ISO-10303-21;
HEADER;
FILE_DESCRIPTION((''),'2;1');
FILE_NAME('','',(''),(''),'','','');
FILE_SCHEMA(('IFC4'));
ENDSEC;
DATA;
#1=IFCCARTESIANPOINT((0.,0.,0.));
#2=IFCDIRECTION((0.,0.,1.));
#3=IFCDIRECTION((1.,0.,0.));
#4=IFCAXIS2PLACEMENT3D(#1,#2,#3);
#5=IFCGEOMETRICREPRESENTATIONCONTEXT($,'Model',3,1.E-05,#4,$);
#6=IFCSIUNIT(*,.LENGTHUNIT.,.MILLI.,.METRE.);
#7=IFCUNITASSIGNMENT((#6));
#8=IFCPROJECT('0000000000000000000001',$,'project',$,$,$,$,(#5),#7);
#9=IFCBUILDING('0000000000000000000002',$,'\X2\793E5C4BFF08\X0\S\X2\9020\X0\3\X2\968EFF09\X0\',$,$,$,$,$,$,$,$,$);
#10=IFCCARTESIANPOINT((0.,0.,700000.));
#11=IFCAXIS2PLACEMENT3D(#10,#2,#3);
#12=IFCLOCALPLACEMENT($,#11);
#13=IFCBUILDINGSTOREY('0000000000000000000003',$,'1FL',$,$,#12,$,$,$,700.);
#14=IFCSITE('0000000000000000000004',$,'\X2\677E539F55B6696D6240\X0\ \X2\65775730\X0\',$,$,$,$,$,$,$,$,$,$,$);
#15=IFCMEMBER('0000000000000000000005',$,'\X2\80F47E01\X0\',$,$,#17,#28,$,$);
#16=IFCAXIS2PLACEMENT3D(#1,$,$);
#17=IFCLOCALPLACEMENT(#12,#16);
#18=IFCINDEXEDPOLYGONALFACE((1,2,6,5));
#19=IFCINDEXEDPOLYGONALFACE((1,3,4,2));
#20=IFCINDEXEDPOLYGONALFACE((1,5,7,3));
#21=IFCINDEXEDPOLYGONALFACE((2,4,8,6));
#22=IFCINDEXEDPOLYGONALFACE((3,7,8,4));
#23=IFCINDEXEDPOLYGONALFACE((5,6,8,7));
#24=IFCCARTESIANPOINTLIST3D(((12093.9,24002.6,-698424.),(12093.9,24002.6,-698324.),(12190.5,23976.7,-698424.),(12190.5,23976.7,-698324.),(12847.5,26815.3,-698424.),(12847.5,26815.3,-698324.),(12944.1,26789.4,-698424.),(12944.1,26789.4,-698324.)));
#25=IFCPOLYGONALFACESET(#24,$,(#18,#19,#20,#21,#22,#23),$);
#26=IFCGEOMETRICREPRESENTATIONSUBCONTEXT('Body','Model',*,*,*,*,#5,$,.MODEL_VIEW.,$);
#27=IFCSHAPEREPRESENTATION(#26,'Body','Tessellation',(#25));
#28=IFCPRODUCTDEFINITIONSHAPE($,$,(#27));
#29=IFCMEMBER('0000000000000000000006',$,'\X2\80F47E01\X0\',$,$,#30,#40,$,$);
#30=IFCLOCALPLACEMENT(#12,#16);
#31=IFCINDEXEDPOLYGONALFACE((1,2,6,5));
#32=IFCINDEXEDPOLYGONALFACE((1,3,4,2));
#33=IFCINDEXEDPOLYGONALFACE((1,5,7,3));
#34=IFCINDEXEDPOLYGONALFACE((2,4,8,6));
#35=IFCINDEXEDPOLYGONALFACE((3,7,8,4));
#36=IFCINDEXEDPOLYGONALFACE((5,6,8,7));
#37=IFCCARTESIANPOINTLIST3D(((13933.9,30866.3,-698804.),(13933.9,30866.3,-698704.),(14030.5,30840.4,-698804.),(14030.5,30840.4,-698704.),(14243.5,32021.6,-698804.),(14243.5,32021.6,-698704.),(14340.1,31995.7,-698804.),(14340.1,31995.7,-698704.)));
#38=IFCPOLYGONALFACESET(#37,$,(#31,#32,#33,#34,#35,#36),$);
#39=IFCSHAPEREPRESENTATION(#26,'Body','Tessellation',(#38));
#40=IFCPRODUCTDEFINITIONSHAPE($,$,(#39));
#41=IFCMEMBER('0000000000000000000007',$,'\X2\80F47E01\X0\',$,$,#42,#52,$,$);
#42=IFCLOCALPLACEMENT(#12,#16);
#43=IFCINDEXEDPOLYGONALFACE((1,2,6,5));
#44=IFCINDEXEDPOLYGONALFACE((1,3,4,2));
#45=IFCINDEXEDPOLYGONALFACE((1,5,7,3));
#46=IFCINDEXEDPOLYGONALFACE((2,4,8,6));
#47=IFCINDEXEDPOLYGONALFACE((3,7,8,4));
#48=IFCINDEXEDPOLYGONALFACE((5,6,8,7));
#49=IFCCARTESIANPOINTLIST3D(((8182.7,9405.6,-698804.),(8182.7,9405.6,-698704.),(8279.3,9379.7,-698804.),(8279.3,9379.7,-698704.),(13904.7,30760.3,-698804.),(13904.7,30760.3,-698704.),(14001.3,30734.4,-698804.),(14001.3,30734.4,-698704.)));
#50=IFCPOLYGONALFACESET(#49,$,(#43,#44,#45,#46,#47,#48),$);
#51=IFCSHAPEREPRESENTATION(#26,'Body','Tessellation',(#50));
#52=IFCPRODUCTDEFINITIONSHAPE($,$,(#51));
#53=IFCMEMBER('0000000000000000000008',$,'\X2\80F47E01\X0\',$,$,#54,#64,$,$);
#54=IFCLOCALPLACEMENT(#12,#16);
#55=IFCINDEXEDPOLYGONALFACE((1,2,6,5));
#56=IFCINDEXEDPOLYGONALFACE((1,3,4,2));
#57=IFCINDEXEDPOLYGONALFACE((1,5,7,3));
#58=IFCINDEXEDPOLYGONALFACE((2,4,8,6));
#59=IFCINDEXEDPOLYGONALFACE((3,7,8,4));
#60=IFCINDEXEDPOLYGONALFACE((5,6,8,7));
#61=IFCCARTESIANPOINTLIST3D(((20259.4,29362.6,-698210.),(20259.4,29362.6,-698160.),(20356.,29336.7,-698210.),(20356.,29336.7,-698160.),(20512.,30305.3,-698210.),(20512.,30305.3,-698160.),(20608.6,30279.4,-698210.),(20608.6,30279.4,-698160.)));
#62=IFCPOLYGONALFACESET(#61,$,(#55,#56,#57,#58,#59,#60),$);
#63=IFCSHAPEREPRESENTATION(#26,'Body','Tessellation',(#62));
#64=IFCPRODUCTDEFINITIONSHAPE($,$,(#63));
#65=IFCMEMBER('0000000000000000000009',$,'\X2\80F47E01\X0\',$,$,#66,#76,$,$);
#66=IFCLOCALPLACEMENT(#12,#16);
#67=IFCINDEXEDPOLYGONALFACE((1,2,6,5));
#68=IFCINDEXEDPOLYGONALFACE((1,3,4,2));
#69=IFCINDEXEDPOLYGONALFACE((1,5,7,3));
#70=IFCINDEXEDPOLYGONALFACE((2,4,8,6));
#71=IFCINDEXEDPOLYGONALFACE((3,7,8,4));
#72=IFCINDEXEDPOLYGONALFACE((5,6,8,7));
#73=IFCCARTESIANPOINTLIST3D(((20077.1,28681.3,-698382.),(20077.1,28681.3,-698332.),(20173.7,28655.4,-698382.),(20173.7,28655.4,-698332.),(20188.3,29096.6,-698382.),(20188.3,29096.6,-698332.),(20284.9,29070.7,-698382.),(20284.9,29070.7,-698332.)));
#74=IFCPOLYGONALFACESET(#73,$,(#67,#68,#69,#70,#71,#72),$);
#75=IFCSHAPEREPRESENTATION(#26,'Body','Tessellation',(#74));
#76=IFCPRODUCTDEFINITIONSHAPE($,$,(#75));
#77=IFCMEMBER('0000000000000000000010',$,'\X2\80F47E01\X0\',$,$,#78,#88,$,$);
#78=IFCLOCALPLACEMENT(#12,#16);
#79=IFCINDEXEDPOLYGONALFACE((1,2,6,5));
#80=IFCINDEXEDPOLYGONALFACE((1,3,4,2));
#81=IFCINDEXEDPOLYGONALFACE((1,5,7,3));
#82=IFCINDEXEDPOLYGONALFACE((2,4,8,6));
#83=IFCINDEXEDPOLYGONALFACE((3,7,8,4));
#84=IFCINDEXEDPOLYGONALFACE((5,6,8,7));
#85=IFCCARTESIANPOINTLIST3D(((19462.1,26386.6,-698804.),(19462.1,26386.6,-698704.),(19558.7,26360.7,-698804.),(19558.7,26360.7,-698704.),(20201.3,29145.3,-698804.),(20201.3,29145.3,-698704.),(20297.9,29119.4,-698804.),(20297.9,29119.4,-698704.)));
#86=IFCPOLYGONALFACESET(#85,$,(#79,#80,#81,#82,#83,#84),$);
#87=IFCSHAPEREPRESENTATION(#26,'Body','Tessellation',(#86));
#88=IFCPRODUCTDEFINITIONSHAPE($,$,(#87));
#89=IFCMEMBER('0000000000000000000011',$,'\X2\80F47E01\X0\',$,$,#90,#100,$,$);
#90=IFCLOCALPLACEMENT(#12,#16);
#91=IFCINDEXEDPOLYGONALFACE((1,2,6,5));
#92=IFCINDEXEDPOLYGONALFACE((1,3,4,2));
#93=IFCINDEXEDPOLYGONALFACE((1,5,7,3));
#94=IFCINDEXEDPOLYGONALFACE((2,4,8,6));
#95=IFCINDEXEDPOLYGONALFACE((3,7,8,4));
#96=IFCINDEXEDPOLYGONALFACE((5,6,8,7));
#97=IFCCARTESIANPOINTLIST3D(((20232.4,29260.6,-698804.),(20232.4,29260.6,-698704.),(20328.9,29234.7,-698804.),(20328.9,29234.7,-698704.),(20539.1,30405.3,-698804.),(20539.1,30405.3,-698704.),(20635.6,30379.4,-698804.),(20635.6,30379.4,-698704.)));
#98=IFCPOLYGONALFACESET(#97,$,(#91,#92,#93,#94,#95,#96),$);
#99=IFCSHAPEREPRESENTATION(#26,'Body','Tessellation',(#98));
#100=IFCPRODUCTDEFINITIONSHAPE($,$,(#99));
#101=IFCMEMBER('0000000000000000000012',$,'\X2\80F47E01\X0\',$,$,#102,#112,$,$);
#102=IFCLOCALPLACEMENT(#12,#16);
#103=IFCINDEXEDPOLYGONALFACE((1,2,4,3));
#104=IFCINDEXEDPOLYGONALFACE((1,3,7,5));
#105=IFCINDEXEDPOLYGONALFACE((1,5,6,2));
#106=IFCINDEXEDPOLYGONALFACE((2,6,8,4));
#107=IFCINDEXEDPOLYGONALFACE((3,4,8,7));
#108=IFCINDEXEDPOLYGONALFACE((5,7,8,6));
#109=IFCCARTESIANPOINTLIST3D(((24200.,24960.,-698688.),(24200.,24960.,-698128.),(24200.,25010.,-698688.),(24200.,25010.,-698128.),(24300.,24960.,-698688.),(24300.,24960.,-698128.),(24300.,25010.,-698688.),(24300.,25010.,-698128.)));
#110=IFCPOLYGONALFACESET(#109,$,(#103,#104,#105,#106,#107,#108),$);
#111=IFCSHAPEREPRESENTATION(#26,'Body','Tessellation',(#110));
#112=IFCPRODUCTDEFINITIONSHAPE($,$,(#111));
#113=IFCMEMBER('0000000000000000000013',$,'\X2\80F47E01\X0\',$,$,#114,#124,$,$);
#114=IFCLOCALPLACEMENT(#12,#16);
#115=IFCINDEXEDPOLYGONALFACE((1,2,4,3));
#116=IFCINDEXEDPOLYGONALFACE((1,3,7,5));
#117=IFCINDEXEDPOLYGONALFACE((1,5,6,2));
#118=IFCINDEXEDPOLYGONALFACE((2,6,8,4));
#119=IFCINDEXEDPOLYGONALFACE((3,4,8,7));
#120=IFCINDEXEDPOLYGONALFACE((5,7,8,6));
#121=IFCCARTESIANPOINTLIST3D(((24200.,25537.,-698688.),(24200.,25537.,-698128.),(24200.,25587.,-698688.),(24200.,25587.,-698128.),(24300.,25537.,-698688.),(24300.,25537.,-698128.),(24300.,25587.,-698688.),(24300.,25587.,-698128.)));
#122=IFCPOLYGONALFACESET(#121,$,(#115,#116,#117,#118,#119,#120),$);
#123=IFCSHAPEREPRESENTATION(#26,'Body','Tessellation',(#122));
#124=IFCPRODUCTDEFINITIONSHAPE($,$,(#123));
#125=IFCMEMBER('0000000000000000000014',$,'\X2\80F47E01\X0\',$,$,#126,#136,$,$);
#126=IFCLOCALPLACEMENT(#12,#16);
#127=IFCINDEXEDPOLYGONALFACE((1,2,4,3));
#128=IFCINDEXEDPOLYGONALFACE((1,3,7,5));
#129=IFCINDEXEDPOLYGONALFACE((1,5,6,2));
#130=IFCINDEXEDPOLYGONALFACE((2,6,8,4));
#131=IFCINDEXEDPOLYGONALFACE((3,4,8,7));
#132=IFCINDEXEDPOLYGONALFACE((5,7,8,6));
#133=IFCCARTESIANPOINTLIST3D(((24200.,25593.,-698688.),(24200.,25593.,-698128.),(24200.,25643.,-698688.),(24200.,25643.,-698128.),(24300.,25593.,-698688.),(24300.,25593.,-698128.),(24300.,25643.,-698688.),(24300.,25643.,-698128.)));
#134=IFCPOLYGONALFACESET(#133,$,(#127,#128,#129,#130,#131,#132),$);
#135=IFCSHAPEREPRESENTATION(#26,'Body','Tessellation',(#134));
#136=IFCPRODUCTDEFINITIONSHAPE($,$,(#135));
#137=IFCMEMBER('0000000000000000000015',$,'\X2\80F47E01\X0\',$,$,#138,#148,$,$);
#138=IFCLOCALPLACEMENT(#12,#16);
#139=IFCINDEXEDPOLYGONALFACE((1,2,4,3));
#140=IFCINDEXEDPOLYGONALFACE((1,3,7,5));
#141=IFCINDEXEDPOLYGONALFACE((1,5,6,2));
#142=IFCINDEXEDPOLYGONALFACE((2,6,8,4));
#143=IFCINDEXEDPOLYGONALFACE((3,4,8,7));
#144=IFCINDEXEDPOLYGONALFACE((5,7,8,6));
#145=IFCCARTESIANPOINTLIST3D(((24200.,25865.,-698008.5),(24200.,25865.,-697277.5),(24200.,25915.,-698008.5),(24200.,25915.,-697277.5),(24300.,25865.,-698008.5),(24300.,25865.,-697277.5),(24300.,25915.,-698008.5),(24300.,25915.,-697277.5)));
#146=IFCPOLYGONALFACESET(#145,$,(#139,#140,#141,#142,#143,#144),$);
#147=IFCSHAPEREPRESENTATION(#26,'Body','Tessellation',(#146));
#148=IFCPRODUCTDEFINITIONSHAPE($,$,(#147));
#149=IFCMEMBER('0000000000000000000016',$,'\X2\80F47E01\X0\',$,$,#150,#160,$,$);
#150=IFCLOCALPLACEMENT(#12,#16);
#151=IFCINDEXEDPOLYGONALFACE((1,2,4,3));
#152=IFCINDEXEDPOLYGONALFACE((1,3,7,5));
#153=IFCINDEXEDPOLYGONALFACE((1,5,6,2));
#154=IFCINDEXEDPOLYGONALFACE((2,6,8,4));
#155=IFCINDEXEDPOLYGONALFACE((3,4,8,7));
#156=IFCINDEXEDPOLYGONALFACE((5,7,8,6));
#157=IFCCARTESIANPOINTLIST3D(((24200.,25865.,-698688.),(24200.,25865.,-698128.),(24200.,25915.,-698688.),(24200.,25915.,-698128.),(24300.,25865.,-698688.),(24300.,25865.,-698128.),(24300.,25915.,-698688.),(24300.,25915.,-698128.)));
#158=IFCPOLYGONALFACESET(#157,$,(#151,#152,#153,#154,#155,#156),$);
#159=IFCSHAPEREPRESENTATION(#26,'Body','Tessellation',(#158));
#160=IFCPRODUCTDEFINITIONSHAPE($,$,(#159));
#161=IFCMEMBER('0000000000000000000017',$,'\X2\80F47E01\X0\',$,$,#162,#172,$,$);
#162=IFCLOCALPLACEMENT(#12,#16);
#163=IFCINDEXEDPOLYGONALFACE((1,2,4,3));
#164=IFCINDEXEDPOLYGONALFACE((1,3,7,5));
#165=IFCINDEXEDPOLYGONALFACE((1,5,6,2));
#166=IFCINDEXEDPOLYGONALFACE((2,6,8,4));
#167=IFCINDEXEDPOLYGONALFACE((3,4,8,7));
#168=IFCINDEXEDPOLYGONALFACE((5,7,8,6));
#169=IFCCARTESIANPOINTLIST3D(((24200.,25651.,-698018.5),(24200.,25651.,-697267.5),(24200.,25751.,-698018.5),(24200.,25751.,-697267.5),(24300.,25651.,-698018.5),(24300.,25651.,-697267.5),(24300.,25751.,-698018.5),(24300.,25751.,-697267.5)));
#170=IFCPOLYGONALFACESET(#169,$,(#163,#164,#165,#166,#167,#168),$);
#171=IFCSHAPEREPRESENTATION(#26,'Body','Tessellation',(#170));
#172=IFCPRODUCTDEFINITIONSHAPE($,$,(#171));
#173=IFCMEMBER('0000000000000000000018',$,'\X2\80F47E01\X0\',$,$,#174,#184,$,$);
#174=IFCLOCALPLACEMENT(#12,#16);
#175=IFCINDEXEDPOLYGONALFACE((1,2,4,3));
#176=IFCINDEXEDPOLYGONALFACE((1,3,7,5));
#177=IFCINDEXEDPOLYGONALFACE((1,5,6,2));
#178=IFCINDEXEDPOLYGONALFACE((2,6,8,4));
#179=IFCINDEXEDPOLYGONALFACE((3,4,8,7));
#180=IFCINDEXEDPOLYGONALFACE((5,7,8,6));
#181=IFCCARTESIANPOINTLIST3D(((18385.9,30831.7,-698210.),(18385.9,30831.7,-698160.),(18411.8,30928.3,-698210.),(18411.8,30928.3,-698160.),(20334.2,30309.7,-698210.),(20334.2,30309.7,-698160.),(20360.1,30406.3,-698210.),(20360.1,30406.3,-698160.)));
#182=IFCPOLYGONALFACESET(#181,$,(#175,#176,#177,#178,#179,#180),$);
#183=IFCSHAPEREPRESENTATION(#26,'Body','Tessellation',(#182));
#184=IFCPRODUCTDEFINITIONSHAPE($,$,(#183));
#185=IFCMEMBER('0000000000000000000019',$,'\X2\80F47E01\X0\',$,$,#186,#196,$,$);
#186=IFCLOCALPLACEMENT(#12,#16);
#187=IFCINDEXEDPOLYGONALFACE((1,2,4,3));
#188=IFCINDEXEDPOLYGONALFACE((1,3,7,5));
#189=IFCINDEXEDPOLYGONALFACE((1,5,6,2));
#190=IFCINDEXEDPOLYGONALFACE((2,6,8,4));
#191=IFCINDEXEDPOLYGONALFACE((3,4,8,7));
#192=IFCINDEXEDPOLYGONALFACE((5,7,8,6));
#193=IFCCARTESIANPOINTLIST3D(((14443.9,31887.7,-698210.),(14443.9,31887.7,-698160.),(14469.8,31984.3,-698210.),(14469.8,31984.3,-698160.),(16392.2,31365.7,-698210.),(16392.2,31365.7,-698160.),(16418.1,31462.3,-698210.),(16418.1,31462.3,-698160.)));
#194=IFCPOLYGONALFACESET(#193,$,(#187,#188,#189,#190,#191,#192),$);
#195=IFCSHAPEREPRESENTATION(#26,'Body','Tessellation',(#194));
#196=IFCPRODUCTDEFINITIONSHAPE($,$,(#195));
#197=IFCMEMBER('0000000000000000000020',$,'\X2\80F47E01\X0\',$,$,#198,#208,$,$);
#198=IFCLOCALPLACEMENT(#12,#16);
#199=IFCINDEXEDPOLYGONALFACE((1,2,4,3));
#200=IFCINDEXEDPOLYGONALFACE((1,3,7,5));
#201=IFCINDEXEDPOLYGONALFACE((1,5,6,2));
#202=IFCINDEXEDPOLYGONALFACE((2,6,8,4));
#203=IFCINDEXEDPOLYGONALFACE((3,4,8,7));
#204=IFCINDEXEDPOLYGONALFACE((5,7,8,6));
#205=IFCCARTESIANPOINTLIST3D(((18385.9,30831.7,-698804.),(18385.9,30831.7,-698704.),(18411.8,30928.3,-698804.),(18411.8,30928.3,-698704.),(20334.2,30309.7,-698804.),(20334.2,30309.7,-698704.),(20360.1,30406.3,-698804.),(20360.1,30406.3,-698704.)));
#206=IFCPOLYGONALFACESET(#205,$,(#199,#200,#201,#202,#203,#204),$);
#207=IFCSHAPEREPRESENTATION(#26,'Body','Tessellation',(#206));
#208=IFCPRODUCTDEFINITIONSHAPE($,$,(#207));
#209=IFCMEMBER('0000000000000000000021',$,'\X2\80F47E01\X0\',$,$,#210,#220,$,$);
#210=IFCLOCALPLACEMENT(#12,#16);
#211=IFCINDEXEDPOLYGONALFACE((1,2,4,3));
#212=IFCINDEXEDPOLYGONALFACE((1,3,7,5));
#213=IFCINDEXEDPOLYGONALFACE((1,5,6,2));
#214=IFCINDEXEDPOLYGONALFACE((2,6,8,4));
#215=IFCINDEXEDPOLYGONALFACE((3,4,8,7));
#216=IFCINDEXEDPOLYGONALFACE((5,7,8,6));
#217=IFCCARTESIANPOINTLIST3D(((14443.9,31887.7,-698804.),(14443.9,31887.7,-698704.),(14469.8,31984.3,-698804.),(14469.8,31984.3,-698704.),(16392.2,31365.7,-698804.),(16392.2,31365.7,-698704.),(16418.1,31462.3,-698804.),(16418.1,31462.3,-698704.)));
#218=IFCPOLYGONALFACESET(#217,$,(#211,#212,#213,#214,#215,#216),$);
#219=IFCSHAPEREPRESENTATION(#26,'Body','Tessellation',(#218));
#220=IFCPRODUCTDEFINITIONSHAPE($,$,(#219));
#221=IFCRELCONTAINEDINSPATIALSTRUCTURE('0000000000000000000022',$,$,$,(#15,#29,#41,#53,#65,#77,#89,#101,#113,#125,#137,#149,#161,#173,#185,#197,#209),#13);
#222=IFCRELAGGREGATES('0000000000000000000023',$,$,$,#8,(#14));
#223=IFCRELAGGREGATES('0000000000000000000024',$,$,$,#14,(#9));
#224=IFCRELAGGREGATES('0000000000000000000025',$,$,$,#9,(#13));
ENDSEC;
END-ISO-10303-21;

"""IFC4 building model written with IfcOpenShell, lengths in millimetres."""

from ifc_helpers import new_model, si_unit, frame, origin, origin_with_axes, place, context, subcontext, project, spatial, rectangle, extrude, element, save


model = new_model("IFC4")

# Units and contexts
model_context = context("Model", 3, precision=1e-05, world=origin_with_axes())
body_context = subcontext(model_context, "Body", "Model", "MODEL_VIEW")
ifc_project = project(units=[si_unit("LENGTHUNIT", "METRE", prefix="MILLI")], contexts=[model_context])

# Site, building, storey
site = spatial("IfcSite", under=ifc_project, Name="松原営業所 敷地")
building = spatial("IfcBuilding", under=site, Name="社屋（S造3階）")
storey_placement = place(None, frame((0.0, 0.0, 700000.0), z_axis=(0.0, 0.0, 1.0), x_axis=(1.0, 0.0, 0.0)))
storey = spatial("IfcBuildingStorey", under=building, at=storey_placement, Name="1FL", Elevation=700.0)

# Members
member_1_placement = place(storey_placement, frame((12895.8, 26802.4, -698374.0), z_axis=(-0.258819, -0.965926, 0.0), x_axis=(0.965926, -0.258819, 0.0)))
element("IfcMember", 1, at=member_1_placement, inside=storey, Name="胴縁", context=body_context, shape_type="SweptSolid", body=[
    extrude(rectangle(XDim=100.0, YDim=100.0), origin(), (0.0, 0.0, 1.0), 2912.0),
])
member_2_placement = place(storey_placement, frame((14291.8, 32008.6, -698754.0), z_axis=(-0.258819, -0.965926, 0.0), x_axis=(0.965926, -0.258819, 0.0)))
element("IfcMember", 2, at=member_2_placement, inside=storey, Name="胴縁", context=body_context, shape_type="SweptSolid", body=[
    extrude(rectangle(XDim=100.0, YDim=100.0), origin(), (0.0, 0.0, 1.0), 1196.0),
])
member_3_placement = place(storey_placement, frame((13953.0, 30747.3, -698754.0), z_axis=(-0.258819, -0.965926, 0.0), x_axis=(0.965926, -0.258819, 0.0)))
element("IfcMember", 3, at=member_3_placement, inside=storey, Name="胴縁", context=body_context, shape_type="SweptSolid", body=[
    extrude(rectangle(XDim=100.0, YDim=100.0), origin(), (0.0, 0.0, 1.0), 22108.0),
])
member_4_placement = place(storey_placement, frame((20307.7, 29349.6, -698185.0), z_axis=(0.258819, 0.965926, 0.0), x_axis=(-0.965926, 0.258819, 0.0)))
element("IfcMember", 4, at=member_4_placement, inside=storey, Name="胴縁", context=body_context, shape_type="SweptSolid", body=[
    extrude(rectangle(XDim=100.0, YDim=50.0), origin(), (0.0, 0.0, 1.0), 976.0),
])
member_5_placement = place(storey_placement, frame((20125.4, 28668.3, -698357.0), z_axis=(0.258819, 0.965926, 0.0), x_axis=(-0.965926, 0.258819, 0.0)))
element("IfcMember", 5, at=member_5_placement, inside=storey, Name="胴縁", context=body_context, shape_type="SweptSolid", body=[
    extrude(rectangle(XDim=100.0, YDim=50.0), origin(), (0.0, 0.0, 1.0), 430.0),
])
member_6_placement = place(storey_placement, frame((19510.4, 26373.7, -698754.0), z_axis=(0.258819, 0.965926, 0.0), x_axis=(-0.965926, 0.258819, 0.0)))
element("IfcMember", 6, at=member_6_placement, inside=storey, Name="胴縁", context=body_context, shape_type="SweptSolid", body=[
    extrude(rectangle(XDim=100.0, YDim=100.0), origin(), (0.0, 0.0, 1.0), 2856.0),
])
member_7_placement = place(storey_placement, frame((20280.6, 29247.7, -698754.0), z_axis=(0.258819, 0.965926, 0.0), x_axis=(-0.965926, 0.258819, 0.0)))
element("IfcMember", 7, at=member_7_placement, inside=storey, Name="胴縁", context=body_context, shape_type="SweptSolid", body=[
    extrude(rectangle(XDim=100.0, YDim=100.0), origin(), (0.0, 0.0, 1.0), 1185.0),
])
for number, where, z_axis, x_axis, name in (
    (8, (24250.0, 24960.0, -698408.0), (0.0, 1.0, 0.0), (-1.0, 0.0, 0.0), "胴縁"),
    (9, (24250.0, 25537.0, -698408.0), (0.0, 1.0, 0.0), (-1.0, 0.0, 0.0), "胴縁"),
    (10, (24250.0, 25593.0, -698408.0), (0.0, 1.0, 0.0), (-1.0, 0.0, 0.0), "胴縁"),
):
    element("IfcMember", number, at=place(storey_placement, frame(where, z_axis=z_axis, x_axis=x_axis)), inside=storey, Name=name, context=body_context, shape_type="SweptSolid", body=[
        extrude(rectangle(XDim=100.0, YDim=560.0), origin(), (0.0, 0.0, 1.0), 50.0),
    ])
member_8_placement = place(storey_placement, frame((24250.0, 25865.0, -697643.0), z_axis=(0.0, 1.0, 0.0), x_axis=(-1.0, 0.0, 0.0)))
element("IfcMember", 11, at=member_8_placement, inside=storey, Name="胴縁", context=body_context, shape_type="SweptSolid", body=[
    extrude(rectangle(XDim=100.0, YDim=731.0), origin(), (0.0, 0.0, 1.0), 50.0),
])
member_9_placement = place(storey_placement, frame((24250.0, 25865.0, -698408.0), z_axis=(0.0, 1.0, 0.0), x_axis=(-1.0, 0.0, 0.0)))
element("IfcMember", 12, at=member_9_placement, inside=storey, Name="胴縁", context=body_context, shape_type="SweptSolid", body=[
    extrude(rectangle(XDim=100.0, YDim=560.0), origin(), (0.0, 0.0, 1.0), 50.0),
])
member_10_placement = place(storey_placement, frame((24250.0, 25651.0, -697643.0), z_axis=(0.0, 1.0, 0.0), x_axis=(-1.0, 0.0, 0.0)))
element("IfcMember", 13, at=member_10_placement, inside=storey, Name="胴縁", context=body_context, shape_type="SweptSolid", body=[
    extrude(rectangle(XDim=100.0, YDim=751.0), origin(), (0.0, 0.0, 1.0), 100.0),
])
for number, where, z_axis, x_axis, name in (
    (14, (20347.1, 30358.0, -698185.0), (-0.965926, 0.258819, 0.0), (-0.258819, -0.965926, 0.0), "胴縁"),
    (15, (16405.1, 31414.0, -698185.0), (-0.965926, 0.258819, 0.0), (-0.258819, -0.965926, 0.0), "胴縁"),
):
    element("IfcMember", number, at=place(storey_placement, frame(where, z_axis=z_axis, x_axis=x_axis)), inside=storey, Name=name, context=body_context, shape_type="SweptSolid", body=[
        extrude(rectangle(XDim=100.0, YDim=50.0), origin(), (0.0, 0.0, 1.0), 2017.0),
    ])
for number, where, z_axis, x_axis, name in (
    (16, (20347.1, 30358.0, -698754.0), (-0.965926, 0.258819, 0.0), (-0.258819, -0.965926, 0.0), "胴縁"),
    (17, (16405.1, 31414.0, -698754.0), (-0.965926, 0.258819, 0.0), (-0.258819, -0.965926, 0.0), "胴縁"),
):
    element("IfcMember", number, at=place(storey_placement, frame(where, z_axis=z_axis, x_axis=x_axis)), inside=storey, Name=name, context=body_context, shape_type="SweptSolid", body=[
        extrude(rectangle(XDim=100.0, YDim=100.0), origin(), (0.0, 0.0, 1.0), 2017.0),
    ])

save(model, "model.ifc")
